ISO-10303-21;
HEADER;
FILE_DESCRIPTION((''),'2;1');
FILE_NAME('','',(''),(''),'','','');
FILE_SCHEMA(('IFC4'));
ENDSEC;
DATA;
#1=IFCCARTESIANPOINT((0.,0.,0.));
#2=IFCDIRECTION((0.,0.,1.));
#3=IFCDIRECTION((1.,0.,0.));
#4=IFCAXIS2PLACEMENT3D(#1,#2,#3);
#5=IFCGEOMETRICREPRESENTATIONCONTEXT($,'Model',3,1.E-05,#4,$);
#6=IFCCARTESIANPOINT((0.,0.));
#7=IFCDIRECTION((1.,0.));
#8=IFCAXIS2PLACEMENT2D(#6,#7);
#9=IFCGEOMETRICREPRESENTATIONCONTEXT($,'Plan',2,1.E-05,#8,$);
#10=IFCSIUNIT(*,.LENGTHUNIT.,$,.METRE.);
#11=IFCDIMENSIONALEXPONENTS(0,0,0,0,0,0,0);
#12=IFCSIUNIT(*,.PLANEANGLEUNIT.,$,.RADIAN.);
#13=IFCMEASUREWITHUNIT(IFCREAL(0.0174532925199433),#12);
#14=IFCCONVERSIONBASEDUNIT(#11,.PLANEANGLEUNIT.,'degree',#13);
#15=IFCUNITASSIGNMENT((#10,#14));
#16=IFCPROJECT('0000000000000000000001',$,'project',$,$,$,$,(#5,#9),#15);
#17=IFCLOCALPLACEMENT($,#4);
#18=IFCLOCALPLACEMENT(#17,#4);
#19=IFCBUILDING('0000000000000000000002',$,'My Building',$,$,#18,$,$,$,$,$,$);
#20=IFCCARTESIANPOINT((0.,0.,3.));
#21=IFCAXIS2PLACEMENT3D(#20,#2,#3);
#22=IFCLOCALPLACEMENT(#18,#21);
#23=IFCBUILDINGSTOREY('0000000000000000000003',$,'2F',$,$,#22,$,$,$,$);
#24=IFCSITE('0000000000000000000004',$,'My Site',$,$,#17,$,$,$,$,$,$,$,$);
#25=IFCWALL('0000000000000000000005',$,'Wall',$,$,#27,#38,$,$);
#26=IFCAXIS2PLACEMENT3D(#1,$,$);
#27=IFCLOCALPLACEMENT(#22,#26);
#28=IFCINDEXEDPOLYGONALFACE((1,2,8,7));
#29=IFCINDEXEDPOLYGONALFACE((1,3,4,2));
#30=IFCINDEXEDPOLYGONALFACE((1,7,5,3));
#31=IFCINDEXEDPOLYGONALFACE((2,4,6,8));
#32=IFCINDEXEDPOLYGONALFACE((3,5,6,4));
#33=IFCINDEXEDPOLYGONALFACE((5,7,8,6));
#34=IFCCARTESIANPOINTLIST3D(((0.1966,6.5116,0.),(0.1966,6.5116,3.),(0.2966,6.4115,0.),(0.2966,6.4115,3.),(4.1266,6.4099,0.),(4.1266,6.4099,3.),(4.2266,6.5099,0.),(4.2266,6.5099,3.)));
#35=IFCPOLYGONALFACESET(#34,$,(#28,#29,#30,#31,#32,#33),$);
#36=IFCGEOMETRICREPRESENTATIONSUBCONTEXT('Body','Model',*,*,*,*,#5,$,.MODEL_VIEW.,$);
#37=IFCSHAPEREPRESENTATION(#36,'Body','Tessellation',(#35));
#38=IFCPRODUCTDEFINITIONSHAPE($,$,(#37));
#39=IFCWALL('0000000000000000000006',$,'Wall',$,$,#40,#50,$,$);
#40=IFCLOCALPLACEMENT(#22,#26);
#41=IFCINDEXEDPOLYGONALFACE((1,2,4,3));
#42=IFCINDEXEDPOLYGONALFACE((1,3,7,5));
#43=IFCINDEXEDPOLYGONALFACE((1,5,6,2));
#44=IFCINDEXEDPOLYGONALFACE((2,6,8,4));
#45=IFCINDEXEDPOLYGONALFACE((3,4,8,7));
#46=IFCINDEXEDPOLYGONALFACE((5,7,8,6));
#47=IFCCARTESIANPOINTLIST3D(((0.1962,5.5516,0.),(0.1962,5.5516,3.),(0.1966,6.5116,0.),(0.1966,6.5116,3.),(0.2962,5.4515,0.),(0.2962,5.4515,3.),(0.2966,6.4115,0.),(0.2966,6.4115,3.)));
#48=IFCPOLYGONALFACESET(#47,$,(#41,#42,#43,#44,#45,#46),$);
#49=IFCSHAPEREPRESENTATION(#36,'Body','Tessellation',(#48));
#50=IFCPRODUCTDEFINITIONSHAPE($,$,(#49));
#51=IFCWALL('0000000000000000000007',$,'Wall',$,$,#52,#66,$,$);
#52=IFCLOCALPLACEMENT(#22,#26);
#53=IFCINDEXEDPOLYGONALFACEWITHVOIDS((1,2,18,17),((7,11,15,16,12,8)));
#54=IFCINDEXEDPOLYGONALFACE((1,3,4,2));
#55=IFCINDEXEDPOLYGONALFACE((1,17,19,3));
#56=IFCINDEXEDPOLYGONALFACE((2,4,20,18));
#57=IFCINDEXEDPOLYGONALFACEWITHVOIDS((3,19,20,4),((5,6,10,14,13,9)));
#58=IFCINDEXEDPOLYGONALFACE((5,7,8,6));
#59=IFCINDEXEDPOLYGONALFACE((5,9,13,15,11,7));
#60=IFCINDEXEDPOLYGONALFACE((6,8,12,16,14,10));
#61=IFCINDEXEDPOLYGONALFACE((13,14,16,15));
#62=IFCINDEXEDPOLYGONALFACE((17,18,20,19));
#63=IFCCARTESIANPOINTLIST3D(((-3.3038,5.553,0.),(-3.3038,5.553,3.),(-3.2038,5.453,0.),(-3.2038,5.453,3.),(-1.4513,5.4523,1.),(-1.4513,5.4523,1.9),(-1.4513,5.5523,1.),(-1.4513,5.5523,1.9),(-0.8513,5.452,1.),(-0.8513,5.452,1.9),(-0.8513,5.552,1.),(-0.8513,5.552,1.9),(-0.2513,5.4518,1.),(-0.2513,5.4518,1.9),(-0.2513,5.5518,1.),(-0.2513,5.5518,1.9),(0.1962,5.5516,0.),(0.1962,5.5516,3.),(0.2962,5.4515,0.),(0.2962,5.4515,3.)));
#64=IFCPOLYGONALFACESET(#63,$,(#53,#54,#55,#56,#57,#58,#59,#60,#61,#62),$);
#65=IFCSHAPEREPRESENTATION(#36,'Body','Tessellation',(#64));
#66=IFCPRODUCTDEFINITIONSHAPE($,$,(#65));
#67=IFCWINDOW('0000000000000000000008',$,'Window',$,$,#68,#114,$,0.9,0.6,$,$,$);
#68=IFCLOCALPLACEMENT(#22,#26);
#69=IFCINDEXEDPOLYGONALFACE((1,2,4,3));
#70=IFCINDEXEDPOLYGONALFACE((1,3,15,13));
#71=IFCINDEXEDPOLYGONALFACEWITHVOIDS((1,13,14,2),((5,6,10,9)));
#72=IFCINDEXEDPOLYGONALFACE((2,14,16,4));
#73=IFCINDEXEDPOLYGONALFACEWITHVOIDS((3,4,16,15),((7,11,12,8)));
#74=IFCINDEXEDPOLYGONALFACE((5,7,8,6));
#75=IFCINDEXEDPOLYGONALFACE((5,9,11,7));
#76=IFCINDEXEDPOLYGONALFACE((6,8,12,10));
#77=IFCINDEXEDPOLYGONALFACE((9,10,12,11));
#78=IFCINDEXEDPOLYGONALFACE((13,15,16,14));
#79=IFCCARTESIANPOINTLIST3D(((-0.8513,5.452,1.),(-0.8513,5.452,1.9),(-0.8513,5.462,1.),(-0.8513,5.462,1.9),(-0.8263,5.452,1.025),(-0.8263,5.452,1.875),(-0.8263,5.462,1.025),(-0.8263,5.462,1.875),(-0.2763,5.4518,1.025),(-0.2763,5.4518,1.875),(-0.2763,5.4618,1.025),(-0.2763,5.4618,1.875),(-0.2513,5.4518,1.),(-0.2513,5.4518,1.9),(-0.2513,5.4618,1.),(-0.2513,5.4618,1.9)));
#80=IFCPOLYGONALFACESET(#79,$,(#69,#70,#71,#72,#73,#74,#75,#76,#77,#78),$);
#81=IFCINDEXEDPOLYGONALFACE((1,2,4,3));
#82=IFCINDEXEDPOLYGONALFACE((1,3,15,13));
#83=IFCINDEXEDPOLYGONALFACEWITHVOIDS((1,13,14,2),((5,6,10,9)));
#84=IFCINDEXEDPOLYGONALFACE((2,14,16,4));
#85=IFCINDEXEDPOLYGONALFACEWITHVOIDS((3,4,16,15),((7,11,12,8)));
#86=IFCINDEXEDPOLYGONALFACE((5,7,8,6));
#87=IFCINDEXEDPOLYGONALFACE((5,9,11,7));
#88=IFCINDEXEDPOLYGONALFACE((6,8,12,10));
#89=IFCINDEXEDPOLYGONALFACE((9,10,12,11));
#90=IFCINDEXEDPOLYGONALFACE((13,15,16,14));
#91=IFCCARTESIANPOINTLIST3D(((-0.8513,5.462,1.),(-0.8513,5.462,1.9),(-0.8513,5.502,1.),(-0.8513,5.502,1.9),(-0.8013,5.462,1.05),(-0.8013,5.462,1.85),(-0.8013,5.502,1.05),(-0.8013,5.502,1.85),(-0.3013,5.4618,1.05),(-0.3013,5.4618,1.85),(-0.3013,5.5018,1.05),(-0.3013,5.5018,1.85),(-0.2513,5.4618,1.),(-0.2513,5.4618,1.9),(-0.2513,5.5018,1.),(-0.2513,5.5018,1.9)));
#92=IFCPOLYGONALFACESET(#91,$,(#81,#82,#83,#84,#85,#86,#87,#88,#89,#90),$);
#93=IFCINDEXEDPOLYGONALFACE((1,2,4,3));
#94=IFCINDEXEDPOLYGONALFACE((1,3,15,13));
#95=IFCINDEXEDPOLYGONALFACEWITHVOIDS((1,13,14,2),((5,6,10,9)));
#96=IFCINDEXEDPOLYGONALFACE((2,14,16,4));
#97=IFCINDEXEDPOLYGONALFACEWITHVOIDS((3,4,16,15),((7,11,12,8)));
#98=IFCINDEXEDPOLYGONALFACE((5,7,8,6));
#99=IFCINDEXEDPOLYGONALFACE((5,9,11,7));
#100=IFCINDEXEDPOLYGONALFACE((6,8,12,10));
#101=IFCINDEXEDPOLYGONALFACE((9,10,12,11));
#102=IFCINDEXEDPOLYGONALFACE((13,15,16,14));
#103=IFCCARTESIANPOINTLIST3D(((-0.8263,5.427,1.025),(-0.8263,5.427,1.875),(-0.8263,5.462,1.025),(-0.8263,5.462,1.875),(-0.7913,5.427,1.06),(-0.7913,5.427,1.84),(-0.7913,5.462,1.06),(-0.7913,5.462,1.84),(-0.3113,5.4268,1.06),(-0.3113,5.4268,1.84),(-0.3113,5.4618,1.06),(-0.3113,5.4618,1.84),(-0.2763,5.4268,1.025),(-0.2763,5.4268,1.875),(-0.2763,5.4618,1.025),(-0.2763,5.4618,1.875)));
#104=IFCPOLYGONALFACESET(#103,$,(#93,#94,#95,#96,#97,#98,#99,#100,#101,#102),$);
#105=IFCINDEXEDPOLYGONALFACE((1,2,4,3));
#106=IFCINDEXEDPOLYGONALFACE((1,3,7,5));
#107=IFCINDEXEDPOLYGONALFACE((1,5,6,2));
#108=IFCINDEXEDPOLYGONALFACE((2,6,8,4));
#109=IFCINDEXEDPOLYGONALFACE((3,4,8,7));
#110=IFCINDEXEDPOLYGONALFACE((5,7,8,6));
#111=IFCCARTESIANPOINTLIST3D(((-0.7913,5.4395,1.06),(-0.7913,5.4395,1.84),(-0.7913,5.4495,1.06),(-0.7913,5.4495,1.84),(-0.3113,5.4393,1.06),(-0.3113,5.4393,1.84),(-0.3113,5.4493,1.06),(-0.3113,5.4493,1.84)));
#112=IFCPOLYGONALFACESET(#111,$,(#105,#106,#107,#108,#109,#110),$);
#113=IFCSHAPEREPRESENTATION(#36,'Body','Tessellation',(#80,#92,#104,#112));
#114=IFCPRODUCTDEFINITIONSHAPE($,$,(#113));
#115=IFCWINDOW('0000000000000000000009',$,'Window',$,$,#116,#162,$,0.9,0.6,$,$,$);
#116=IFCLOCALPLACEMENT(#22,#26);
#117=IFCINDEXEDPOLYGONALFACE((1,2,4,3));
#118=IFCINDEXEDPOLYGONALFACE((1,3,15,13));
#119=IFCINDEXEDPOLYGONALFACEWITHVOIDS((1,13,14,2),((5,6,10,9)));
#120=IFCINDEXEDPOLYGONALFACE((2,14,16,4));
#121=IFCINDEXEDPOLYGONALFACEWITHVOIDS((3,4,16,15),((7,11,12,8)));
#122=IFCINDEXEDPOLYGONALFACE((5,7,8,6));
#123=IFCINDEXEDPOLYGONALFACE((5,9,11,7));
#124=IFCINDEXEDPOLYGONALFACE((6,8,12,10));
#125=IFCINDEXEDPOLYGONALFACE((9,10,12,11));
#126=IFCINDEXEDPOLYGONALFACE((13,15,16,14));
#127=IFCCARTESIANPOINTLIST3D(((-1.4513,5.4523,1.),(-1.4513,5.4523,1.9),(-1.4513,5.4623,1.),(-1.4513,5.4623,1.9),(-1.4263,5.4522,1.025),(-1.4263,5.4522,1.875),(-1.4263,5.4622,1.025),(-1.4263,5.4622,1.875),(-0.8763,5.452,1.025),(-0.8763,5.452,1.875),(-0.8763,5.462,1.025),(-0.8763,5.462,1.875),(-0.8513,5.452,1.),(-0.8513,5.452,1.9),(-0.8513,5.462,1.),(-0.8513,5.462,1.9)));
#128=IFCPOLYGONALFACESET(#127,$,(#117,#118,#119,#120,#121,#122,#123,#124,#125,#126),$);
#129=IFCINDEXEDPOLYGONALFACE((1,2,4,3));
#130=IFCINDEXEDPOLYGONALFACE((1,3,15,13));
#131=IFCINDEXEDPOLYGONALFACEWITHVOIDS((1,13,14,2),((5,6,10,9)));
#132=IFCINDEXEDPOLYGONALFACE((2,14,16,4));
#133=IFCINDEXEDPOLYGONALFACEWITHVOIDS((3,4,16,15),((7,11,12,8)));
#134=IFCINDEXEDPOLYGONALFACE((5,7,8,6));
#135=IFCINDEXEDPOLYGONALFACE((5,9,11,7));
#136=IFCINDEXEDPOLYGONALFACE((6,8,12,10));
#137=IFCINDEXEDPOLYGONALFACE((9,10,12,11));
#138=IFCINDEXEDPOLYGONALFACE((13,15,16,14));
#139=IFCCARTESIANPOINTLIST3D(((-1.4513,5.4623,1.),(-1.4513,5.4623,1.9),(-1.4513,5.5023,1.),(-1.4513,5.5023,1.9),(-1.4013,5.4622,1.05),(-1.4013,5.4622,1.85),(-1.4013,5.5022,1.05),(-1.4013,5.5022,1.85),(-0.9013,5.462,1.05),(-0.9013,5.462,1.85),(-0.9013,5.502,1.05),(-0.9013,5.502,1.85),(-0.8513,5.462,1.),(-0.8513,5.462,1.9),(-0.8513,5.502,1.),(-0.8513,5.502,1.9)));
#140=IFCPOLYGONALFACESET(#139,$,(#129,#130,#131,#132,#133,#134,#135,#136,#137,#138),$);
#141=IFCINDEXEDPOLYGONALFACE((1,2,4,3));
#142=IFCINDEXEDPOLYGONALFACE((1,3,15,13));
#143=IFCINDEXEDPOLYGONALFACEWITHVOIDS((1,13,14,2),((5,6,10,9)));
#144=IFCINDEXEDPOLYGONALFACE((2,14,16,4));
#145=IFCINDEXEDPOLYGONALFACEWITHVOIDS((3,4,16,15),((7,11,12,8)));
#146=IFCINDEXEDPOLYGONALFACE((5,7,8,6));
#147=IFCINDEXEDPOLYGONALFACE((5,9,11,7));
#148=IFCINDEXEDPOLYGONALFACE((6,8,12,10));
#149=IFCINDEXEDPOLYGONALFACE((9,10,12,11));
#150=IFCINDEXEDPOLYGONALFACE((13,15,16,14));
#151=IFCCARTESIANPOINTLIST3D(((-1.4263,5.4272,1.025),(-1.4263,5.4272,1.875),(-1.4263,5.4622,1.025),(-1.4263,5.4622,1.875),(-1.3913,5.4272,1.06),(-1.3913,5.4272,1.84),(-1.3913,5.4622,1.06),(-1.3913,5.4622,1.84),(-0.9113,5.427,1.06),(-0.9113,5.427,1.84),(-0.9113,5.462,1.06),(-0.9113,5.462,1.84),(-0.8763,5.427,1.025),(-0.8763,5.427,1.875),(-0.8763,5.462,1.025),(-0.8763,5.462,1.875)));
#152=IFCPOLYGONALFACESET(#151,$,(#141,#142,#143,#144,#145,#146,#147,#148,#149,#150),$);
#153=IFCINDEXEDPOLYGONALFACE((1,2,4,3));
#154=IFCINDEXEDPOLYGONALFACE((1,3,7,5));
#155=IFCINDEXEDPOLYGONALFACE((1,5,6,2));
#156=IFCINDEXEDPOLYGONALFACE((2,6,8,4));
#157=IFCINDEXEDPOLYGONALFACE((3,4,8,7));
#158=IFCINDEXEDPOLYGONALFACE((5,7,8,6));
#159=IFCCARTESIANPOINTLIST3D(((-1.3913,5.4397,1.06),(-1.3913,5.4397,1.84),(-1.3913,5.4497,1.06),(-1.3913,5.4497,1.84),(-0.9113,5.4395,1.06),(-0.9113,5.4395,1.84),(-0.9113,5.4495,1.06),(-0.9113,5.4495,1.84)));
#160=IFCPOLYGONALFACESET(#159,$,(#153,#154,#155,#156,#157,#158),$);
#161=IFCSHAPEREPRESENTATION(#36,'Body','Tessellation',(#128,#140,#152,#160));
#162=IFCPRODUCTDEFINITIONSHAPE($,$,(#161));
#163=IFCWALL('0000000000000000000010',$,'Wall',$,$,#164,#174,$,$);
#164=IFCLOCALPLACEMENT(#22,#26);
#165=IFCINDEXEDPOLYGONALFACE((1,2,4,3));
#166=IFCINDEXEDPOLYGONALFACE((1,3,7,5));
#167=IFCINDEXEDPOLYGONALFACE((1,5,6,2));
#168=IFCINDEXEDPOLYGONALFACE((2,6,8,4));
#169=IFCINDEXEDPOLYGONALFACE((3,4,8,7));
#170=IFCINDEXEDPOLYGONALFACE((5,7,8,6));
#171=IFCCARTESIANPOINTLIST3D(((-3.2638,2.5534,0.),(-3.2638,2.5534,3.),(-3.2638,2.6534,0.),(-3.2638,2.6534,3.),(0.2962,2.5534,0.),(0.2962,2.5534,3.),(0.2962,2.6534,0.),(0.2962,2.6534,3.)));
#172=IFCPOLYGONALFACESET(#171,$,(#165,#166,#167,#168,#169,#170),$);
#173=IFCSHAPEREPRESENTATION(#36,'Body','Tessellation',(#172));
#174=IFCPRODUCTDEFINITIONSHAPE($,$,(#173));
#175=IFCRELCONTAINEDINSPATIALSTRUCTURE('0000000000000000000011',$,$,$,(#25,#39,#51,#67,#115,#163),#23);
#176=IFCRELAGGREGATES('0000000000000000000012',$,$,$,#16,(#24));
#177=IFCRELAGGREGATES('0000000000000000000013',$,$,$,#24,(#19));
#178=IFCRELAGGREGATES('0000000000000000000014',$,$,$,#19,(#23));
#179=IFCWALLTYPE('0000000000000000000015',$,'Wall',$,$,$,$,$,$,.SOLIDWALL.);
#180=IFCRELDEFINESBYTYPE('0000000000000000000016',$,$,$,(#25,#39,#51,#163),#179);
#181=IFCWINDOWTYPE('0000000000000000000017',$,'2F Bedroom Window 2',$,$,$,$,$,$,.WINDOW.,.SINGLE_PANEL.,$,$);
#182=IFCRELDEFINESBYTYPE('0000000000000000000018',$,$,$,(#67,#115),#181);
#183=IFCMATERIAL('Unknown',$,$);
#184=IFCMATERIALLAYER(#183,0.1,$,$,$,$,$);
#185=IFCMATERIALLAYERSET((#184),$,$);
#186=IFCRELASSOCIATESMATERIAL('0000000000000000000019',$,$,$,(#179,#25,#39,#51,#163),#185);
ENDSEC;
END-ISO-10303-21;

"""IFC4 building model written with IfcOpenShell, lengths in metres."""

from ifc_helpers import new_model, entity, si_unit, converted_unit, frame, origin_with_axes, origin_2d_with_axis, place, context, subcontext, project, spatial, line, indexed_curve, outline, extrude, shape, source, transform, mapped, material, layer, layer_set, layer_usage, type_object, type_shapes, element, fill, save


model = new_model("IFC4")

# Units and contexts
model_context = context("Model", 3, precision=1e-05, world=origin_with_axes())
plan_context = context("Plan", 2, precision=1e-05, world=origin_2d_with_axis())
body_context_1 = subcontext(model_context, "Body", "Model", "MODEL_VIEW")
body_context_2 = subcontext(plan_context, "Body", "Plan", "PLAN_VIEW")
ifc_project = project(units=[si_unit("LENGTHUNIT", "METRE"), converted_unit("PLANEANGLEUNIT", "degree", entity("IfcReal", 0.0174532925199433), si_unit("PLANEANGLEUNIT", "RADIAN"), dimensions=[0, 0, 0, 0, 0, 0, 0])], contexts=[model_context, plan_context])

# Site, building, storey
site_placement = place(None, origin_with_axes())
site = spatial("IfcSite", under=ifc_project, at=site_placement, Name="My Site")
building_placement = place(site_placement, origin_with_axes())
building = spatial("IfcBuilding", under=site, at=building_placement, Name="My Building")
storey_placement = place(building_placement, frame((0.0, 0.0, 3.0), z_axis=(0.0, 0.0, 1.0), x_axis=(1.0, 0.0, 0.0)))
storey = spatial("IfcBuildingStorey", under=building, at=storey_placement, Name="2F")

# Walls
ifc_material = material(Name="Unknown")
ifc_layer = layer(ifc_material, 0.1)
ifc_layer_set = layer_set([ifc_layer])
ifc_layer_usage_1 = layer_usage(ifc_layer_set, "AXIS2", "POSITIVE", 0.0)
wall_type = type_object("IfcWallType", Name="Wall", PredefinedType="SOLIDWALL", material=ifc_layer_set)
wall_1_placement = place(storey_placement, frame((4.2266, 6.5099, 0.0), z_axis=(0.0, 0.0, 1.0), x_axis=(-1.0, 0.000415, 0.0)))
element("IfcWall", 1, at=wall_1_placement, inside=storey, type_object=wall_type, material=ifc_layer_usage_1, Name="Wall", context=body_context_1, shape_type="SweptSolid", body=[
    extrude(outline(indexed_curve([(0.0, 0.0), (0.1, 0.1), (3.93, 0.1), (4.03, 0.0)], segments=[line(1, 2, 3, 4, 1)])), origin_with_axes(), (0.0, 0.0, 1.0), 3.0),
])
ifc_layer_usage_2 = layer_usage(ifc_layer_set, "AXIS2", "POSITIVE", 0.0)
wall_2_placement = place(storey_placement, frame((0.1966, 6.5116, 0.0), z_axis=(0.0, 0.0, 1.0), x_axis=(-0.000415, -1.0, 0.0)))
element("IfcWall", 2, at=wall_2_placement, inside=storey, type_object=wall_type, material=ifc_layer_usage_2, Name="Wall", context=body_context_1, shape_type="SweptSolid", body=[
    extrude(outline(indexed_curve([(0.0, 0.0), (0.1, 0.1), (1.06, 0.1), (0.96, 0.0)], segments=[line(1, 2, 3, 4, 1)])), origin_with_axes(), (0.0, 0.0, 1.0), 3.0),
])

# Wall, openings, windows
ifc_layer_usage_3 = layer_usage(ifc_layer_set, "AXIS2", "POSITIVE", 0.0)
wall_3_placement = place(storey_placement, frame((0.1962, 5.5516, 0.0), z_axis=(0.0, 0.0, 1.0), x_axis=(-1.0, 0.000416, 0.0)))
wall_3 = element("IfcWall", 3, at=wall_3_placement, inside=storey, type_object=wall_type, material=ifc_layer_usage_3, Name="Wall", context=body_context_1, shape_type="SweptSolid", body=[
    extrude(outline(indexed_curve([(0.0, 0.0), (-0.1, 0.1), (3.4, 0.1), (3.5, 0.0)], segments=[line(1, 2, 3, 4, 1)])), origin_with_axes(), (0.0, 0.0, 1.0), 3.0),
])
shared_shape_1 = source(origin_with_axes(), body_context_1, "Body", "SweptSolid", [
    extrude(outline(indexed_curve([(0.0, 0.0), (0.6, 0.0), (0.6, 0.9), (0.0, 0.9)], segments=[line(1, 2, 3, 4, 1)])), frame((0.0, -0.6, 0.0), z_axis=(0.0, -1.0, 0.0), x_axis=(1.0, 0.0, 0.0)), (0.0, 0.0, -1.0), 1.2),
])
opening_1_placement = place(wall_3_placement, frame((0.4475, 0.0, 1.0), z_axis=(0.0, 0.0, 1.0), x_axis=(1.0, 0.0, 0.0)))
opening_1 = element("IfcOpeningElement", 4, at=opening_1_placement, cuts=wall_3, PredefinedType="OPENING", context=body_context_1, shape_type="MappedRepresentation", body=[
    mapped(shared_shape_1, transform((0.0, 0.0, 0.0), x_axis=(1.0, 0.0, 0.0), y_axis=(0.0, 1.0, 0.0), z_axis=(0.0, 0.0, 1.0), scale=1.0)),
])
opening_2_placement = place(wall_3_placement, frame((1.0475, 0.0, 1.0), z_axis=(0.0, 0.0, 1.0), x_axis=(1.0, 0.0, 0.0)))
opening_2 = element("IfcOpeningElement", 5, at=opening_2_placement, cuts=wall_3, PredefinedType="OPENING", context=body_context_1, shape_type="MappedRepresentation", body=[
    mapped(shared_shape_1, transform((0.0, 0.0, 0.0), x_axis=(1.0, 0.0, 0.0), y_axis=(0.0, 1.0, 0.0), z_axis=(0.0, 0.0, 1.0), scale=1.0)),
])
window_type_1 = type_object("IfcWindowType", Name="2F Bedroom Window 2", PartitioningType="SINGLE_PANEL", PredefinedType="WINDOW")
shared_shape_2 = source(origin_with_axes(), body_context_1, "Body", "SweptSolid", [
    extrude(outline(indexed_curve([(0.0, 0.0), (0.6, 0.0), (0.6, 0.9), (0.0, 0.9)], segments=[line(1, 2, 3, 4, 1)]), holes=[indexed_curve([(0.025, 0.025), (0.575, 0.025), (0.575, 0.875), (0.025, 0.875)], segments=[line(1, 2, 3, 4, 1)])]), frame((0.0, 0.09, 0.0), z_axis=(0.0, -1.0, 0.0), x_axis=(1.0, 0.0, 0.0)), (0.0, 0.0, -1.0), 0.01),
    extrude(outline(indexed_curve([(0.0, 0.0), (0.6, 0.0), (0.6, 0.9), (0.0, 0.9)], segments=[line(1, 2, 3, 4, 1)]), holes=[indexed_curve([(0.05, 0.05), (0.55, 0.05), (0.55, 0.85), (0.05, 0.85)], segments=[line(1, 2, 3, 4, 1)])]), frame((0.0, 0.05, 0.0), z_axis=(0.0, -1.0, 0.0), x_axis=(1.0, 0.0, 0.0)), (0.0, 0.0, -1.0), 0.04),
    extrude(outline(indexed_curve([(0.0, 0.0), (0.55, 0.0), (0.55, 0.85), (0.0, 0.85)], segments=[line(1, 2, 3, 4, 1)]), holes=[indexed_curve([(0.035, 0.035), (0.515, 0.035), (0.515, 0.815), (0.035, 0.815)], segments=[line(1, 2, 3, 4, 1)])]), frame((0.025, 0.09, 0.025), z_axis=(0.0, -1.0, 0.0), x_axis=(1.0, 0.0, 0.0)), (0.0, 0.0, -1.0), 0.035),
    extrude(outline(indexed_curve([(0.035, 0.035), (0.515, 0.035), (0.515, 0.815), (0.035, 0.815)], segments=[line(1, 2, 3, 4, 1)])), frame((0.025, 0.1025, 0.025), z_axis=(0.0, -1.0, 0.0), x_axis=(1.0, 0.0, 0.0)), (0.0, 0.0, -1.0), 0.01),
])
shared_shape_3 = source(origin_with_axes(), body_context_2, "Body", "Curve2D", [
    entity("IfcIndexedPolyCurve", entity("IfcCartesianPointList2D", [[0.05, 0.05], [0.55, 0.05]])),
    entity("IfcIndexedPolyCurve", entity("IfcCartesianPointList2D", [[0.0, 0.1], [0.025, 0.1], [0.025, 0.09], [0.05, 0.09], [0.05, 0.05], [0.0, 0.05]]), [entity("IfcLineIndex", [1, 2, 3, 4, 5, 6, 1])]),
    entity("IfcIndexedPolyCurve", entity("IfcCartesianPointList2D", [[0.6, 0.1], [0.575, 0.1], [0.575, 0.09], [0.55, 0.09], [0.55, 0.05], [0.6, 0.05]]), [entity("IfcLineIndex", [1, 2, 3, 4, 5, 6, 1])]),
    entity("IfcIndexedPolyCurve", entity("IfcCartesianPointList2D", [[0.025, 0.09], [0.06, 0.09], [0.06, 0.125], [0.025, 0.125]]), [entity("IfcLineIndex", [1, 2, 3, 4, 1])]),
    entity("IfcIndexedPolyCurve", entity("IfcCartesianPointList2D", [[0.575, 0.09], [0.54, 0.09], [0.54, 0.125], [0.575, 0.125]]), [entity("IfcLineIndex", [1, 2, 3, 4, 1])]),
    entity("IfcIndexedPolyCurve", entity("IfcCartesianPointList2D", [[0.06, 0.09], [0.54, 0.09]])),
    entity("IfcIndexedPolyCurve", entity("IfcCartesianPointList2D", [[0.06, 0.125], [0.54, 0.125]])),
    entity("IfcIndexedPolyCurve", entity("IfcCartesianPointList2D", [[0.06, 0.1075], [0.54, 0.1075]])),
])
type_shapes(window_type_1, [shared_shape_2, shared_shape_3])
window_1_placement = place(opening_1_placement, frame((0.0, 0.0, 0.0), z_axis=(0.0, 0.0, 1.0), x_axis=(1.0, 0.0, 0.0)))
window_1 = element("IfcWindow", 6, at=window_1_placement, inside=storey, type_object=window_type_1, Name="Window", OverallHeight=0.9, OverallWidth=0.6, shapes=[
    shape(body_context_1, "Body", "MappedRepresentation", [mapped(shared_shape_2, transform((0.0, 0.0, 0.0), x_axis=(1.0, 0.0, 0.0), y_axis=(0.0, 1.0, 0.0), z_axis=(0.0, 0.0, 1.0), scale=1.0))]),
    shape(body_context_2, "Body", "MappedRepresentation", [mapped(shared_shape_3, transform((0.0, 0.0, 0.0), x_axis=(1.0, 0.0, 0.0), y_axis=(0.0, 1.0, 0.0), z_axis=(0.0, 0.0, 1.0), scale=1.0))]),
])
fill(opening_1, window_1)
window_2_placement = place(opening_2_placement, origin_with_axes())
window_2 = element("IfcWindow", 7, at=window_2_placement, inside=storey, type_object=window_type_1, Name="Window", OverallHeight=0.9, OverallWidth=0.6, shapes=[
    shape(body_context_1, "Body", "MappedRepresentation", [mapped(shared_shape_2, transform((0.0, 0.0, 0.0), x_axis=(1.0, 0.0, 0.0), y_axis=(0.0, 1.0, 0.0), z_axis=(0.0, 0.0, 1.0), scale=1.0))]),
    shape(body_context_2, "Body", "MappedRepresentation", [mapped(shared_shape_3, transform((0.0, 0.0, 0.0), x_axis=(1.0, 0.0, 0.0), y_axis=(0.0, 1.0, 0.0), z_axis=(0.0, 0.0, 1.0), scale=1.0))]),
])
fill(opening_2, window_2)

# Wall
ifc_layer_usage_4 = layer_usage(ifc_layer_set, "AXIS2", "POSITIVE", 0.0)
wall_4_placement = place(storey_placement, frame((-3.2638, 2.5534, 0.0), z_axis=(0.0, 0.0, 1.0), x_axis=(1.0, 0.0, 0.0)))
element("IfcWall", 8, at=wall_4_placement, inside=storey, type_object=wall_type, material=ifc_layer_usage_4, Name="Wall", context=body_context_1, shape_type="SweptSolid", body=[
    extrude(outline(indexed_curve([(0.0, 0.0), (0.0, 0.1), (3.56, 0.1), (3.56, 0.0)], segments=[line(1, 2, 3, 4, 1)])), origin_with_axes(), (0.0, 0.0, 1.0), 3.0),
])

save(model, "model.ifc")
